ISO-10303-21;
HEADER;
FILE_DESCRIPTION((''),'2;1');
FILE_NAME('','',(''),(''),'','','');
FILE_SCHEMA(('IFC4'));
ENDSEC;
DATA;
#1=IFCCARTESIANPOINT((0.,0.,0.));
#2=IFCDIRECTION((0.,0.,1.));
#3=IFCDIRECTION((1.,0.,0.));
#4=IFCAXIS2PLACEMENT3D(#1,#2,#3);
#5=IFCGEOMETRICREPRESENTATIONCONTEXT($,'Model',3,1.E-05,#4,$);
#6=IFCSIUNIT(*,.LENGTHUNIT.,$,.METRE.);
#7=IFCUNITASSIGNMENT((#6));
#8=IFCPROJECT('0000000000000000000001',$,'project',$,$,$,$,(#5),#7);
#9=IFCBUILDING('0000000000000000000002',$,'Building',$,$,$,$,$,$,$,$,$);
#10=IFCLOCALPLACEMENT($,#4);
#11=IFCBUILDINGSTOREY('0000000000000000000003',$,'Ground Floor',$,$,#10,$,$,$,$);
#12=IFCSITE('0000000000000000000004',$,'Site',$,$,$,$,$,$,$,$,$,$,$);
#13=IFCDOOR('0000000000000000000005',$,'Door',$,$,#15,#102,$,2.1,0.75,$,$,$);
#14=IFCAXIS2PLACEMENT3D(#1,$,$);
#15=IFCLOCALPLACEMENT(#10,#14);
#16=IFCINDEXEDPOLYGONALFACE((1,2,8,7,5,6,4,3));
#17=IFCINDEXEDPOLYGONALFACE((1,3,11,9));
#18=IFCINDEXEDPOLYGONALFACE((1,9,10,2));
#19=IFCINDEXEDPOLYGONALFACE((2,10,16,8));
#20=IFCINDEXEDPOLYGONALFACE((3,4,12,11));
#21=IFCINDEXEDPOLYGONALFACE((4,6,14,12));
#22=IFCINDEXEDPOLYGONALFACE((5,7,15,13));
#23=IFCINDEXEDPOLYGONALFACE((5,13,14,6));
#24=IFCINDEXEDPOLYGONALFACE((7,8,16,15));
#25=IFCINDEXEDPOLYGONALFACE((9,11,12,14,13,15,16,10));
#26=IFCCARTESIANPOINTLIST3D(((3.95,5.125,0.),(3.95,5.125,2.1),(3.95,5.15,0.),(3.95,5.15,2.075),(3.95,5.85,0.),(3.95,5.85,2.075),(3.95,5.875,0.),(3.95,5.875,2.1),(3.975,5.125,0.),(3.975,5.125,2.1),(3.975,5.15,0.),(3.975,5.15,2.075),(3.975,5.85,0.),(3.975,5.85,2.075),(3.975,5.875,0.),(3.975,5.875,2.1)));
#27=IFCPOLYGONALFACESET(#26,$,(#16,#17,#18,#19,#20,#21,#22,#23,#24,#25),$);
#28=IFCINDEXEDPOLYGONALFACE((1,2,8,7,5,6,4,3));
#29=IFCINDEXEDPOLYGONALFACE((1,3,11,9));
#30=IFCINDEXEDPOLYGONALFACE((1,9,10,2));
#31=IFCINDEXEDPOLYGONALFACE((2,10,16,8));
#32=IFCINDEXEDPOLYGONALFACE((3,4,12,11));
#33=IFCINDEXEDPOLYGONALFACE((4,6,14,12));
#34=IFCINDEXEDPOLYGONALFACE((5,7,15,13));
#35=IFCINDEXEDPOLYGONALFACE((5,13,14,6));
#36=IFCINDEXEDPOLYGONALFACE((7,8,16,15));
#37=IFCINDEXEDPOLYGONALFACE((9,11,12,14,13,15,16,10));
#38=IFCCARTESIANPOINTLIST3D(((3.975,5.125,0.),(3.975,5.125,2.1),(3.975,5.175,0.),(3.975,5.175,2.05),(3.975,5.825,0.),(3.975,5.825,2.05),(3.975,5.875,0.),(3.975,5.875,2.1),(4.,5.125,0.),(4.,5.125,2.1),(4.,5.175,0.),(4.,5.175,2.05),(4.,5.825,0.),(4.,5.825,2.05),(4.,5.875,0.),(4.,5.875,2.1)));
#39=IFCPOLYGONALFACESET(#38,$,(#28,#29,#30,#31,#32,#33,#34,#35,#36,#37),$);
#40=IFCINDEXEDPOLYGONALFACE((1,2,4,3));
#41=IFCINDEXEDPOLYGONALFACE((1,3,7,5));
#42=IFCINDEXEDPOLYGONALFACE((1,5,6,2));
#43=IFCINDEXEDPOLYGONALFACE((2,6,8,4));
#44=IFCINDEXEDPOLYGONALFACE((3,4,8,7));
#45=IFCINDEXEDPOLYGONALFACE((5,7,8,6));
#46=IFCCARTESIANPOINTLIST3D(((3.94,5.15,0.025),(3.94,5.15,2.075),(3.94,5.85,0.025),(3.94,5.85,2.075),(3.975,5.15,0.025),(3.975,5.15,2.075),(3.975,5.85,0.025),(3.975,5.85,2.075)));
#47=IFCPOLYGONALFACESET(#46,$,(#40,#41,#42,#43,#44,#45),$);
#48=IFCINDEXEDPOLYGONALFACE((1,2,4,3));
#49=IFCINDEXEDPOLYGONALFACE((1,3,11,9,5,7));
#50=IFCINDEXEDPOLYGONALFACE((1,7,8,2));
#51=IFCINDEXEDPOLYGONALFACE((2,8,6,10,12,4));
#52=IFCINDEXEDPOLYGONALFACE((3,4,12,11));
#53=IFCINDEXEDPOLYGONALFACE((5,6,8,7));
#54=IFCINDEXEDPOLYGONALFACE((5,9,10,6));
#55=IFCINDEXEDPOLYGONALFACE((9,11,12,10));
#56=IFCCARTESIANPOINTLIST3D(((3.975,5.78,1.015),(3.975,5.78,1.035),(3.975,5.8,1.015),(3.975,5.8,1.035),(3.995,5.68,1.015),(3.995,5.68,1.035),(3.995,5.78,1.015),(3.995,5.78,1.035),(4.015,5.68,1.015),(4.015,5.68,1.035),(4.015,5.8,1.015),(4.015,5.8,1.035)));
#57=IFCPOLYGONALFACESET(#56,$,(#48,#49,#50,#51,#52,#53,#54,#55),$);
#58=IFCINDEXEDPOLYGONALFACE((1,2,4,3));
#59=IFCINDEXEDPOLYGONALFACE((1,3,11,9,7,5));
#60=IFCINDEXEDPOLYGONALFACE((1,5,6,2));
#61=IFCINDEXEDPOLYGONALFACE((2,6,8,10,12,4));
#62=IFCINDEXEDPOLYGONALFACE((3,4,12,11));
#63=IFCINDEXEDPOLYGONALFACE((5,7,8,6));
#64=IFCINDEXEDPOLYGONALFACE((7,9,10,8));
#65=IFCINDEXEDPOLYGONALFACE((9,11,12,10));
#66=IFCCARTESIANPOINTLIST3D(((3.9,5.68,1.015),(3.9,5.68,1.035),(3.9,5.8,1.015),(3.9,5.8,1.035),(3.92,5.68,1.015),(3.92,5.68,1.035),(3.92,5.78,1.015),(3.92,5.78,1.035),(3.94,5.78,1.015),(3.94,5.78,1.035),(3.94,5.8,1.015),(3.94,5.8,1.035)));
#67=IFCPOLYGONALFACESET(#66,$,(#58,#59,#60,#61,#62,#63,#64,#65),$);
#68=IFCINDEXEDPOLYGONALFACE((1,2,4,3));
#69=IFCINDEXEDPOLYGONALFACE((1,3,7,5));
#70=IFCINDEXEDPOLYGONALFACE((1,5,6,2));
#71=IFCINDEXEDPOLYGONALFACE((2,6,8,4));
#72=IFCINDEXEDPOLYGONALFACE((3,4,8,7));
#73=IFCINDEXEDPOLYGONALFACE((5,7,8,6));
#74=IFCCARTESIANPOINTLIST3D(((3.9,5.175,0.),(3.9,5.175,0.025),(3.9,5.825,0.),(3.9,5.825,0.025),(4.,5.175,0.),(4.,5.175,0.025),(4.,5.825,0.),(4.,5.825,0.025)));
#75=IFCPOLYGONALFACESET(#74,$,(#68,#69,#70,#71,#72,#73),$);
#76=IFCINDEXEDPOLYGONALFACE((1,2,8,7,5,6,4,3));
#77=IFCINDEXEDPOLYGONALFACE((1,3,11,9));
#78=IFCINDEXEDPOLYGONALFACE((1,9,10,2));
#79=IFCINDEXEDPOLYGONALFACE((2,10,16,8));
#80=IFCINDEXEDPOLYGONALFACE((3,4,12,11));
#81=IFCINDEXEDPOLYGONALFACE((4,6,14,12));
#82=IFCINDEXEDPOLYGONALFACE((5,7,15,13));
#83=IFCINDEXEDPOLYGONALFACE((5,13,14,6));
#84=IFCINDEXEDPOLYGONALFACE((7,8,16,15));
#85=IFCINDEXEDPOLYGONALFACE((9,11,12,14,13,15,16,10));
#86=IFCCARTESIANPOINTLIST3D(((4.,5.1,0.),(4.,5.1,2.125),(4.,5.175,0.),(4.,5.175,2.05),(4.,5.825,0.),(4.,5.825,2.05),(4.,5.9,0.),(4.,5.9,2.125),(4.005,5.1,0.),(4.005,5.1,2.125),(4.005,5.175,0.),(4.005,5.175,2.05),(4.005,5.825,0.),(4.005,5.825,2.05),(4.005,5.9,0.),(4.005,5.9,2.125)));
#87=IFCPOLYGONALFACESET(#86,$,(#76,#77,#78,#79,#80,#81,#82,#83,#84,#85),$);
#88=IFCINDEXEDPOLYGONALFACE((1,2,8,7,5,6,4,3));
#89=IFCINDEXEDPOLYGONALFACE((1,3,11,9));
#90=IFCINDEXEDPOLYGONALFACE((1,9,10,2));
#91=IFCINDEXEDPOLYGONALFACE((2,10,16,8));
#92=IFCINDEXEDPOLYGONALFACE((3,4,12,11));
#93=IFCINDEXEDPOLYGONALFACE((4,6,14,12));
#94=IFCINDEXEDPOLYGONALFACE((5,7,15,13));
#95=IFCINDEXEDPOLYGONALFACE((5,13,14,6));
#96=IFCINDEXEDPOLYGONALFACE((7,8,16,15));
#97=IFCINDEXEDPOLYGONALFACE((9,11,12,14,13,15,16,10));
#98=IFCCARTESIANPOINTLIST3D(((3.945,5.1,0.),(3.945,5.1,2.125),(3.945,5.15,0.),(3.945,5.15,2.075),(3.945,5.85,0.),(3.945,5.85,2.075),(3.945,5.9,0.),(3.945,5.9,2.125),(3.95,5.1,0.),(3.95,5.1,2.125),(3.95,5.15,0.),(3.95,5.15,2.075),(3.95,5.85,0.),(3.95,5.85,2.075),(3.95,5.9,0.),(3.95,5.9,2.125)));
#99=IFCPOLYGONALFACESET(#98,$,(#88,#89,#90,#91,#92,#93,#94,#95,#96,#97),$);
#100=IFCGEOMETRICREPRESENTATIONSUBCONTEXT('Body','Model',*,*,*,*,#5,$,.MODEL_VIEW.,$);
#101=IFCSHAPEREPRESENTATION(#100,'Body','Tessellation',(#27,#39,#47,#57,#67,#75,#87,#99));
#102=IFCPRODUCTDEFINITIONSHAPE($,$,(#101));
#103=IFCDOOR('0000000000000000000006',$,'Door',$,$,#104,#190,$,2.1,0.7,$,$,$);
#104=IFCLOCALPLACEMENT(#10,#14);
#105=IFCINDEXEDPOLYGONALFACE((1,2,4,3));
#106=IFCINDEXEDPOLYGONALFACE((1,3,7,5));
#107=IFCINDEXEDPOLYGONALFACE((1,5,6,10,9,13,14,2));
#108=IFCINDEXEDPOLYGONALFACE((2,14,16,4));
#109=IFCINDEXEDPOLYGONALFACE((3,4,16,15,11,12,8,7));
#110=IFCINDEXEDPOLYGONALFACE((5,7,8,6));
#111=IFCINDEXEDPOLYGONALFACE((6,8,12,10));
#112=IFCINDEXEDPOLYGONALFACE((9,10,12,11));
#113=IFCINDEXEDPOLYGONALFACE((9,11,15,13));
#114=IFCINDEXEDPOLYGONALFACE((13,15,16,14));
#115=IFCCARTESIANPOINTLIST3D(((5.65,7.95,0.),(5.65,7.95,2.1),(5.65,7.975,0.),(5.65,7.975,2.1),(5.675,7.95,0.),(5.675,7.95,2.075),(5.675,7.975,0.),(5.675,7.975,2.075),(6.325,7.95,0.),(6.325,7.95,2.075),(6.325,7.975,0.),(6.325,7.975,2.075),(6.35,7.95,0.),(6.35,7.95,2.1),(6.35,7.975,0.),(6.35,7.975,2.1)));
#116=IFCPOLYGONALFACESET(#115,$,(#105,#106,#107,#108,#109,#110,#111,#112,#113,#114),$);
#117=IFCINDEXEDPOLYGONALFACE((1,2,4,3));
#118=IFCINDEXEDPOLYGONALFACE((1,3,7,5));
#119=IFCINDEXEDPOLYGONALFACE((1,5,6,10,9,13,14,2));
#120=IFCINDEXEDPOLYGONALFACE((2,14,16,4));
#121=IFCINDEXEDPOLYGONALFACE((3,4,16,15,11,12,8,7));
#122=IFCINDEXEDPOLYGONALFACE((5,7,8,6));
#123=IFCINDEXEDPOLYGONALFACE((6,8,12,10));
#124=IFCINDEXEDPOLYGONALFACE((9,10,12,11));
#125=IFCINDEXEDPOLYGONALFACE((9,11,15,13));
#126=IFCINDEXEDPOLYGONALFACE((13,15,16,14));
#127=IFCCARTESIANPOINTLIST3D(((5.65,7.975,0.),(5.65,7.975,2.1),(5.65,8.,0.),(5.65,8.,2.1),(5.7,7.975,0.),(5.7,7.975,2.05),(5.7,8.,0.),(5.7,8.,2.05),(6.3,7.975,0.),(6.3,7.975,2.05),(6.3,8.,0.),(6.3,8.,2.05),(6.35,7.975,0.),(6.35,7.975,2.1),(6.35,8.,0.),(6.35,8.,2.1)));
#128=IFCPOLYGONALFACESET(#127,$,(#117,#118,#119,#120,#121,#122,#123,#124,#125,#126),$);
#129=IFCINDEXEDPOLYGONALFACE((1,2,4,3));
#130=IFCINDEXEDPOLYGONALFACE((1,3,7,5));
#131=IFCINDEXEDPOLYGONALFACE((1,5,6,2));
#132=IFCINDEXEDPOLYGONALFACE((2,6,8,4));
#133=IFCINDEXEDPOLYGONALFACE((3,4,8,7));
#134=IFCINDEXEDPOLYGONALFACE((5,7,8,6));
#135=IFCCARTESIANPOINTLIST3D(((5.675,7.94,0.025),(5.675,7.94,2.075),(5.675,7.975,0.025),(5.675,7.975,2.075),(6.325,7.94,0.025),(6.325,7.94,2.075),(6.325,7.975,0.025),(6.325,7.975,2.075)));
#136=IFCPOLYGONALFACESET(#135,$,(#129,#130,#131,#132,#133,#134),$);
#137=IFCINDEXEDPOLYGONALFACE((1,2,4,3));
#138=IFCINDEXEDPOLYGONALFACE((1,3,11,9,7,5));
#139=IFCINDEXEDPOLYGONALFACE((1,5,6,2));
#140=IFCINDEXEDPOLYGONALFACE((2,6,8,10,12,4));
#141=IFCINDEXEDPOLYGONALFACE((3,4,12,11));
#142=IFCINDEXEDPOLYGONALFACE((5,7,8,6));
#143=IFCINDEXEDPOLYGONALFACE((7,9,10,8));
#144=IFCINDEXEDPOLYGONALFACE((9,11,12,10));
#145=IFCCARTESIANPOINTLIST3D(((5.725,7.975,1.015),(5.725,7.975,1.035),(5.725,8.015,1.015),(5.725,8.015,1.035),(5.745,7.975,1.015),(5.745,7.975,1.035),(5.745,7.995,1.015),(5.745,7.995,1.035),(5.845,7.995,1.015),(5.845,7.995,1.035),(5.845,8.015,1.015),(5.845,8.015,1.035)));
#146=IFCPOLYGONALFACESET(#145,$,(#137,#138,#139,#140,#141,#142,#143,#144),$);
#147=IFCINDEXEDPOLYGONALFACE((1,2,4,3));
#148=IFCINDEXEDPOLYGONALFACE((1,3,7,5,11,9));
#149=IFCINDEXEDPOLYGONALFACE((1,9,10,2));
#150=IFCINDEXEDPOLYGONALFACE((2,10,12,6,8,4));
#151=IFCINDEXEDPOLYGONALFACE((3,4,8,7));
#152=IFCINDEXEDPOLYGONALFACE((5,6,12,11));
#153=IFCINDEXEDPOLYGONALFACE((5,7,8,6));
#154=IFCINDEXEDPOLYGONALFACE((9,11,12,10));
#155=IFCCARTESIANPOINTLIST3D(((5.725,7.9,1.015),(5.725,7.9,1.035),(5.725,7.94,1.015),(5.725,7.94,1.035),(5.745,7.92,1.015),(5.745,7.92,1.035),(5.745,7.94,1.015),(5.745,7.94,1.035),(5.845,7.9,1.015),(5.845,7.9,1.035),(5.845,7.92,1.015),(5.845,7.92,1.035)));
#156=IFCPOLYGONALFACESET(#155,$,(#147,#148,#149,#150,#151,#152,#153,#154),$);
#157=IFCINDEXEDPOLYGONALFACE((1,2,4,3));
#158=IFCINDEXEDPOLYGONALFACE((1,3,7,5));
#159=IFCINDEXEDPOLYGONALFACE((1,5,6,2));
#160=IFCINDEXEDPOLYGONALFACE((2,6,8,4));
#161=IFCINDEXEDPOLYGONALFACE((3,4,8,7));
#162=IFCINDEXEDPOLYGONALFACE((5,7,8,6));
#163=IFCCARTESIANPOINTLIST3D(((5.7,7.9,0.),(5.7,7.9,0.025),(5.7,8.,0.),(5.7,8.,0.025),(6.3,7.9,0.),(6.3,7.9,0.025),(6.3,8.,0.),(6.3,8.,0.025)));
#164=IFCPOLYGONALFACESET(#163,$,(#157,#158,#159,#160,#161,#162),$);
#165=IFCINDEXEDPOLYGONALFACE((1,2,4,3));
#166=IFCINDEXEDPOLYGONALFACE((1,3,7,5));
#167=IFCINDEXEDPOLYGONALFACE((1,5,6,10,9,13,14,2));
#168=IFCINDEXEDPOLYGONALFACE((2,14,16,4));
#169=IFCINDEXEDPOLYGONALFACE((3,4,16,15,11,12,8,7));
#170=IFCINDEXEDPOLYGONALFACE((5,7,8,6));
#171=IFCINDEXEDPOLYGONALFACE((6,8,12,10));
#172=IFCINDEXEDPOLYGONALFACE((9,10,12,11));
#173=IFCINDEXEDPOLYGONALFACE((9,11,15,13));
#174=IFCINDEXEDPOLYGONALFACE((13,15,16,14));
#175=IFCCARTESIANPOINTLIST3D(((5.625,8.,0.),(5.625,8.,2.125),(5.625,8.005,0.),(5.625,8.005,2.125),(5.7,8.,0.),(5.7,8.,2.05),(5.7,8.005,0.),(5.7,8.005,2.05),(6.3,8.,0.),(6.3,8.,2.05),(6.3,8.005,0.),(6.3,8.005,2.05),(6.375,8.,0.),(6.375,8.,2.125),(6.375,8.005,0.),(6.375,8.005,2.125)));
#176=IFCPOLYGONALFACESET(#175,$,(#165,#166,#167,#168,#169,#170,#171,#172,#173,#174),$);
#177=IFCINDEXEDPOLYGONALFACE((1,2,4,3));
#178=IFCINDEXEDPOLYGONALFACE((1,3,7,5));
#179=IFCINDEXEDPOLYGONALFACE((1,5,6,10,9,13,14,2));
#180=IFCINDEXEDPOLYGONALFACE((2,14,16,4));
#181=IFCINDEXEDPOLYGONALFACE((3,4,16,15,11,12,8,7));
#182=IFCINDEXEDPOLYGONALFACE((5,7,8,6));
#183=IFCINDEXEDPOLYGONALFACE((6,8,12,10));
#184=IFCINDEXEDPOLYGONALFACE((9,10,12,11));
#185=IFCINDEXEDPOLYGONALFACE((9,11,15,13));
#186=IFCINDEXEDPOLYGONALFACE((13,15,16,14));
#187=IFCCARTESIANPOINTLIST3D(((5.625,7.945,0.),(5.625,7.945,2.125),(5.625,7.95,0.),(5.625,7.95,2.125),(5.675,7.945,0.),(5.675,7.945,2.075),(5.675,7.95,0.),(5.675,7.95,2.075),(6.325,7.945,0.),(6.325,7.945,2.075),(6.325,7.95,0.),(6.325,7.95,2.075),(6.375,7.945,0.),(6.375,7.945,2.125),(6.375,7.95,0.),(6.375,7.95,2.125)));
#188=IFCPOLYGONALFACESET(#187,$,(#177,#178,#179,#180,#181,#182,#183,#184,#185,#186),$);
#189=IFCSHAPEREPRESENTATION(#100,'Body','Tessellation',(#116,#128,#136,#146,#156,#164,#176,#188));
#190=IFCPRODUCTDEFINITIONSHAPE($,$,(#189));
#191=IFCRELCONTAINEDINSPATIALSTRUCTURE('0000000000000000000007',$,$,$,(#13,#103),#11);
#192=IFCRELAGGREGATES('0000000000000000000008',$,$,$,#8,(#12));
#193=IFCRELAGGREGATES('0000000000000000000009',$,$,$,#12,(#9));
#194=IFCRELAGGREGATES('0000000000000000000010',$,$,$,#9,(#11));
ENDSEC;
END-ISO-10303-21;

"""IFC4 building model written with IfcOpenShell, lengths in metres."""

from ifc_helpers import new_model, si_unit, frame, origin_with_axes, place, context, subcontext, project, spatial, line, indexed_curve, outline, extrude, element, save


model = new_model("IFC4")

# Units and contexts
model_context = context("Model", 3, precision=1e-05, world=origin_with_axes())
body_context = subcontext(model_context, "Body", "Model", "MODEL_VIEW")
ifc_project = project(units=[si_unit("LENGTHUNIT", "METRE")], contexts=[model_context])

# Site, building, storey
site = spatial("IfcSite", under=ifc_project, Name="Site")
building = spatial("IfcBuilding", under=site, Name="Building")
storey_placement = place(None, origin_with_axes())
storey = spatial("IfcBuildingStorey", under=building, at=storey_placement, Name="Ground Floor")

# Doors
door_1_placement = place(storey_placement, frame((4.0, 5.125, 0.0), z_axis=(0.0, 0.0, 1.0), x_axis=(0.0, 1.0, 0.0)))
element("IfcDoor", 1, at=door_1_placement, inside=storey, Name="Door", OverallHeight=2.1, OverallWidth=0.75, context=body_context, shape_type="SweptSolid", body=[
    extrude(outline(indexed_curve([(0.0, 0.0), (0.0, 2.1), (0.75, 2.1), (0.75, 0.0), (0.725, 0.0), (0.725, 2.075), (0.025, 2.075), (0.025, 0.0)], segments=[line(1, 2, 3, 4, 5, 6, 7, 8, 1)])), frame((0.0, 0.025, 0.0), z_axis=(0.0, -1.0, 0.0), x_axis=(1.0, 0.0, 0.0)), (0.0, 0.0, -1.0), 0.025),
    extrude(outline(indexed_curve([(0.0, 0.0), (0.0, 2.1), (0.75, 2.1), (0.75, 0.0), (0.7, 0.0), (0.7, 2.05), (0.05, 2.05), (0.05, 0.0)], segments=[line(1, 2, 3, 4, 5, 6, 7, 8, 1)])), frame((0.0, 0.0, 0.0), z_axis=(0.0, -1.0, 0.0), x_axis=(1.0, 0.0, 0.0)), (0.0, 0.0, -1.0), 0.025),
    extrude(outline(indexed_curve([(0.0, 0.0), (0.7, 0.0), (0.7, 0.035), (0.0, 0.035)], segments=[line(1, 2, 3, 4, 1)])), frame((0.025, 0.025, 0.025), z_axis=(0.0, 0.0, 1.0), x_axis=(1.0, 0.0, 0.0)), (0.0, 0.0, 1.0), 2.05),
    extrude(outline(indexed_curve([(0.0, 0.0), (0.0, -0.04), (-0.12, -0.04), (-0.12, -0.02), (-0.02, -0.02), (-0.02, 0.0)], segments=[line(1, 2, 3, 4, 5, 6, 1)])), frame((0.675, 0.025, 1.015), z_axis=(0.0, 0.0, 1.0), x_axis=(1.0, 0.0, 0.0)), (0.0, 0.0, 1.0), 0.02),
    extrude(outline(indexed_curve([(0.0, 0.0), (0.0, 0.04), (-0.12, 0.04), (-0.12, 0.02), (-0.02, 0.02), (-0.02, 0.0)], segments=[line(1, 2, 3, 4, 5, 6, 1)])), frame((0.675, 0.06, 1.015), z_axis=(0.0, 0.0, 1.0), x_axis=(1.0, 0.0, 0.0)), (0.0, 0.0, 1.0), 0.02),
    extrude(outline(indexed_curve([(0.0, 0.0), (0.65, 0.0), (0.65, 0.1), (0.0, 0.1)], segments=[line(1, 2, 3, 4, 1)])), frame((0.05, 0.0, 0.0), z_axis=(0.0, 0.0, 1.0), x_axis=(1.0, 0.0, 0.0)), (0.0, 0.0, 1.0), 0.025),
    extrude(outline(indexed_curve([(0.0, 0.0), (0.0, 2.125), (0.8, 2.125), (0.8, 0.0), (0.725, 0.0), (0.725, 2.05), (0.075, 2.05), (0.075, 0.0)], segments=[line(1, 2, 3, 4, 5, 6, 7, 8, 1)])), frame((-0.025, -0.005, 0.0), z_axis=(0.0, -1.0, 0.0), x_axis=(1.0, 0.0, 0.0)), (0.0, 0.0, -1.0), 0.005),
    extrude(outline(indexed_curve([(0.0, 0.0), (0.0, 2.125), (0.8, 2.125), (0.8, 0.0), (0.75, 0.0), (0.75, 2.075), (0.05, 2.075), (0.05, 0.0)], segments=[line(1, 2, 3, 4, 5, 6, 7, 8, 1)])), frame((-0.025, 0.05, 0.0), z_axis=(0.0, -1.0, 0.0), x_axis=(1.0, 0.0, 0.0)), (0.0, 0.0, -1.0), 0.005),
])
door_2_placement = place(storey_placement, frame((6.35, 8.0, 0.0), z_axis=(0.0, 0.0, 1.0), x_axis=(-1.0, 0.0, 0.0)))
element("IfcDoor", 2, at=door_2_placement, inside=storey, Name="Door", OverallHeight=2.1, OverallWidth=0.7, context=body_context, shape_type="SweptSolid", body=[
    extrude(outline(indexed_curve([(0.0, 0.0), (0.0, 2.1), (0.7, 2.1), (0.7, 0.0), (0.675, 0.0), (0.675, 2.075), (0.025, 2.075), (0.025, 0.0)], segments=[line(1, 2, 3, 4, 5, 6, 7, 8, 1)])), frame((0.0, 0.025, 0.0), z_axis=(0.0, -1.0, 0.0), x_axis=(1.0, 0.0, 0.0)), (0.0, 0.0, -1.0), 0.025),
    extrude(outline(indexed_curve([(0.0, 0.0), (0.0, 2.1), (0.7, 2.1), (0.7, 0.0), (0.65, 0.0), (0.65, 2.05), (0.05, 2.05), (0.05, 0.0)], segments=[line(1, 2, 3, 4, 5, 6, 7, 8, 1)])), frame((0.0, 0.0, 0.0), z_axis=(0.0, -1.0, 0.0), x_axis=(1.0, 0.0, 0.0)), (0.0, 0.0, -1.0), 0.025),
    extrude(outline(indexed_curve([(0.0, 0.0), (0.65, 0.0), (0.65, 0.035), (0.0, 0.035)], segments=[line(1, 2, 3, 4, 1)])), frame((0.025, 0.025, 0.025), z_axis=(0.0, 0.0, 1.0), x_axis=(1.0, 0.0, 0.0)), (0.0, 0.0, 1.0), 2.05),
    extrude(outline(indexed_curve([(0.0, 0.0), (0.0, -0.04), (-0.12, -0.04), (-0.12, -0.02), (-0.02, -0.02), (-0.02, 0.0)], segments=[line(1, 2, 3, 4, 5, 6, 1)])), frame((0.625, 0.025, 1.015), z_axis=(0.0, 0.0, 1.0), x_axis=(1.0, 0.0, 0.0)), (0.0, 0.0, 1.0), 0.02),
    extrude(outline(indexed_curve([(0.0, 0.0), (0.0, 0.04), (-0.12, 0.04), (-0.12, 0.02), (-0.02, 0.02), (-0.02, 0.0)], segments=[line(1, 2, 3, 4, 5, 6, 1)])), frame((0.625, 0.06, 1.015), z_axis=(0.0, 0.0, 1.0), x_axis=(1.0, 0.0, 0.0)), (0.0, 0.0, 1.0), 0.02),
    extrude(outline(indexed_curve([(0.0, 0.0), (0.6, 0.0), (0.6, 0.1), (0.0, 0.1)], segments=[line(1, 2, 3, 4, 1)])), frame((0.05, 0.0, 0.0), z_axis=(0.0, 0.0, 1.0), x_axis=(1.0, 0.0, 0.0)), (0.0, 0.0, 1.0), 0.025),
    extrude(outline(indexed_curve([(0.0, 0.0), (0.0, 2.125), (0.75, 2.125), (0.75, 0.0), (0.675, 0.0), (0.675, 2.05), (0.075, 2.05), (0.075, 0.0)], segments=[line(1, 2, 3, 4, 5, 6, 7, 8, 1)])), frame((-0.025, -0.005, 0.0), z_axis=(0.0, -1.0, 0.0), x_axis=(1.0, 0.0, 0.0)), (0.0, 0.0, -1.0), 0.005),
    extrude(outline(indexed_curve([(0.0, 0.0), (0.0, 2.125), (0.75, 2.125), (0.75, 0.0), (0.7, 0.0), (0.7, 2.075), (0.05, 2.075), (0.05, 0.0)], segments=[line(1, 2, 3, 4, 5, 6, 7, 8, 1)])), frame((-0.025, 0.05, 0.0), z_axis=(0.0, -1.0, 0.0), x_axis=(1.0, 0.0, 0.0)), (0.0, 0.0, -1.0), 0.005),
])

save(model, "model.ifc")
